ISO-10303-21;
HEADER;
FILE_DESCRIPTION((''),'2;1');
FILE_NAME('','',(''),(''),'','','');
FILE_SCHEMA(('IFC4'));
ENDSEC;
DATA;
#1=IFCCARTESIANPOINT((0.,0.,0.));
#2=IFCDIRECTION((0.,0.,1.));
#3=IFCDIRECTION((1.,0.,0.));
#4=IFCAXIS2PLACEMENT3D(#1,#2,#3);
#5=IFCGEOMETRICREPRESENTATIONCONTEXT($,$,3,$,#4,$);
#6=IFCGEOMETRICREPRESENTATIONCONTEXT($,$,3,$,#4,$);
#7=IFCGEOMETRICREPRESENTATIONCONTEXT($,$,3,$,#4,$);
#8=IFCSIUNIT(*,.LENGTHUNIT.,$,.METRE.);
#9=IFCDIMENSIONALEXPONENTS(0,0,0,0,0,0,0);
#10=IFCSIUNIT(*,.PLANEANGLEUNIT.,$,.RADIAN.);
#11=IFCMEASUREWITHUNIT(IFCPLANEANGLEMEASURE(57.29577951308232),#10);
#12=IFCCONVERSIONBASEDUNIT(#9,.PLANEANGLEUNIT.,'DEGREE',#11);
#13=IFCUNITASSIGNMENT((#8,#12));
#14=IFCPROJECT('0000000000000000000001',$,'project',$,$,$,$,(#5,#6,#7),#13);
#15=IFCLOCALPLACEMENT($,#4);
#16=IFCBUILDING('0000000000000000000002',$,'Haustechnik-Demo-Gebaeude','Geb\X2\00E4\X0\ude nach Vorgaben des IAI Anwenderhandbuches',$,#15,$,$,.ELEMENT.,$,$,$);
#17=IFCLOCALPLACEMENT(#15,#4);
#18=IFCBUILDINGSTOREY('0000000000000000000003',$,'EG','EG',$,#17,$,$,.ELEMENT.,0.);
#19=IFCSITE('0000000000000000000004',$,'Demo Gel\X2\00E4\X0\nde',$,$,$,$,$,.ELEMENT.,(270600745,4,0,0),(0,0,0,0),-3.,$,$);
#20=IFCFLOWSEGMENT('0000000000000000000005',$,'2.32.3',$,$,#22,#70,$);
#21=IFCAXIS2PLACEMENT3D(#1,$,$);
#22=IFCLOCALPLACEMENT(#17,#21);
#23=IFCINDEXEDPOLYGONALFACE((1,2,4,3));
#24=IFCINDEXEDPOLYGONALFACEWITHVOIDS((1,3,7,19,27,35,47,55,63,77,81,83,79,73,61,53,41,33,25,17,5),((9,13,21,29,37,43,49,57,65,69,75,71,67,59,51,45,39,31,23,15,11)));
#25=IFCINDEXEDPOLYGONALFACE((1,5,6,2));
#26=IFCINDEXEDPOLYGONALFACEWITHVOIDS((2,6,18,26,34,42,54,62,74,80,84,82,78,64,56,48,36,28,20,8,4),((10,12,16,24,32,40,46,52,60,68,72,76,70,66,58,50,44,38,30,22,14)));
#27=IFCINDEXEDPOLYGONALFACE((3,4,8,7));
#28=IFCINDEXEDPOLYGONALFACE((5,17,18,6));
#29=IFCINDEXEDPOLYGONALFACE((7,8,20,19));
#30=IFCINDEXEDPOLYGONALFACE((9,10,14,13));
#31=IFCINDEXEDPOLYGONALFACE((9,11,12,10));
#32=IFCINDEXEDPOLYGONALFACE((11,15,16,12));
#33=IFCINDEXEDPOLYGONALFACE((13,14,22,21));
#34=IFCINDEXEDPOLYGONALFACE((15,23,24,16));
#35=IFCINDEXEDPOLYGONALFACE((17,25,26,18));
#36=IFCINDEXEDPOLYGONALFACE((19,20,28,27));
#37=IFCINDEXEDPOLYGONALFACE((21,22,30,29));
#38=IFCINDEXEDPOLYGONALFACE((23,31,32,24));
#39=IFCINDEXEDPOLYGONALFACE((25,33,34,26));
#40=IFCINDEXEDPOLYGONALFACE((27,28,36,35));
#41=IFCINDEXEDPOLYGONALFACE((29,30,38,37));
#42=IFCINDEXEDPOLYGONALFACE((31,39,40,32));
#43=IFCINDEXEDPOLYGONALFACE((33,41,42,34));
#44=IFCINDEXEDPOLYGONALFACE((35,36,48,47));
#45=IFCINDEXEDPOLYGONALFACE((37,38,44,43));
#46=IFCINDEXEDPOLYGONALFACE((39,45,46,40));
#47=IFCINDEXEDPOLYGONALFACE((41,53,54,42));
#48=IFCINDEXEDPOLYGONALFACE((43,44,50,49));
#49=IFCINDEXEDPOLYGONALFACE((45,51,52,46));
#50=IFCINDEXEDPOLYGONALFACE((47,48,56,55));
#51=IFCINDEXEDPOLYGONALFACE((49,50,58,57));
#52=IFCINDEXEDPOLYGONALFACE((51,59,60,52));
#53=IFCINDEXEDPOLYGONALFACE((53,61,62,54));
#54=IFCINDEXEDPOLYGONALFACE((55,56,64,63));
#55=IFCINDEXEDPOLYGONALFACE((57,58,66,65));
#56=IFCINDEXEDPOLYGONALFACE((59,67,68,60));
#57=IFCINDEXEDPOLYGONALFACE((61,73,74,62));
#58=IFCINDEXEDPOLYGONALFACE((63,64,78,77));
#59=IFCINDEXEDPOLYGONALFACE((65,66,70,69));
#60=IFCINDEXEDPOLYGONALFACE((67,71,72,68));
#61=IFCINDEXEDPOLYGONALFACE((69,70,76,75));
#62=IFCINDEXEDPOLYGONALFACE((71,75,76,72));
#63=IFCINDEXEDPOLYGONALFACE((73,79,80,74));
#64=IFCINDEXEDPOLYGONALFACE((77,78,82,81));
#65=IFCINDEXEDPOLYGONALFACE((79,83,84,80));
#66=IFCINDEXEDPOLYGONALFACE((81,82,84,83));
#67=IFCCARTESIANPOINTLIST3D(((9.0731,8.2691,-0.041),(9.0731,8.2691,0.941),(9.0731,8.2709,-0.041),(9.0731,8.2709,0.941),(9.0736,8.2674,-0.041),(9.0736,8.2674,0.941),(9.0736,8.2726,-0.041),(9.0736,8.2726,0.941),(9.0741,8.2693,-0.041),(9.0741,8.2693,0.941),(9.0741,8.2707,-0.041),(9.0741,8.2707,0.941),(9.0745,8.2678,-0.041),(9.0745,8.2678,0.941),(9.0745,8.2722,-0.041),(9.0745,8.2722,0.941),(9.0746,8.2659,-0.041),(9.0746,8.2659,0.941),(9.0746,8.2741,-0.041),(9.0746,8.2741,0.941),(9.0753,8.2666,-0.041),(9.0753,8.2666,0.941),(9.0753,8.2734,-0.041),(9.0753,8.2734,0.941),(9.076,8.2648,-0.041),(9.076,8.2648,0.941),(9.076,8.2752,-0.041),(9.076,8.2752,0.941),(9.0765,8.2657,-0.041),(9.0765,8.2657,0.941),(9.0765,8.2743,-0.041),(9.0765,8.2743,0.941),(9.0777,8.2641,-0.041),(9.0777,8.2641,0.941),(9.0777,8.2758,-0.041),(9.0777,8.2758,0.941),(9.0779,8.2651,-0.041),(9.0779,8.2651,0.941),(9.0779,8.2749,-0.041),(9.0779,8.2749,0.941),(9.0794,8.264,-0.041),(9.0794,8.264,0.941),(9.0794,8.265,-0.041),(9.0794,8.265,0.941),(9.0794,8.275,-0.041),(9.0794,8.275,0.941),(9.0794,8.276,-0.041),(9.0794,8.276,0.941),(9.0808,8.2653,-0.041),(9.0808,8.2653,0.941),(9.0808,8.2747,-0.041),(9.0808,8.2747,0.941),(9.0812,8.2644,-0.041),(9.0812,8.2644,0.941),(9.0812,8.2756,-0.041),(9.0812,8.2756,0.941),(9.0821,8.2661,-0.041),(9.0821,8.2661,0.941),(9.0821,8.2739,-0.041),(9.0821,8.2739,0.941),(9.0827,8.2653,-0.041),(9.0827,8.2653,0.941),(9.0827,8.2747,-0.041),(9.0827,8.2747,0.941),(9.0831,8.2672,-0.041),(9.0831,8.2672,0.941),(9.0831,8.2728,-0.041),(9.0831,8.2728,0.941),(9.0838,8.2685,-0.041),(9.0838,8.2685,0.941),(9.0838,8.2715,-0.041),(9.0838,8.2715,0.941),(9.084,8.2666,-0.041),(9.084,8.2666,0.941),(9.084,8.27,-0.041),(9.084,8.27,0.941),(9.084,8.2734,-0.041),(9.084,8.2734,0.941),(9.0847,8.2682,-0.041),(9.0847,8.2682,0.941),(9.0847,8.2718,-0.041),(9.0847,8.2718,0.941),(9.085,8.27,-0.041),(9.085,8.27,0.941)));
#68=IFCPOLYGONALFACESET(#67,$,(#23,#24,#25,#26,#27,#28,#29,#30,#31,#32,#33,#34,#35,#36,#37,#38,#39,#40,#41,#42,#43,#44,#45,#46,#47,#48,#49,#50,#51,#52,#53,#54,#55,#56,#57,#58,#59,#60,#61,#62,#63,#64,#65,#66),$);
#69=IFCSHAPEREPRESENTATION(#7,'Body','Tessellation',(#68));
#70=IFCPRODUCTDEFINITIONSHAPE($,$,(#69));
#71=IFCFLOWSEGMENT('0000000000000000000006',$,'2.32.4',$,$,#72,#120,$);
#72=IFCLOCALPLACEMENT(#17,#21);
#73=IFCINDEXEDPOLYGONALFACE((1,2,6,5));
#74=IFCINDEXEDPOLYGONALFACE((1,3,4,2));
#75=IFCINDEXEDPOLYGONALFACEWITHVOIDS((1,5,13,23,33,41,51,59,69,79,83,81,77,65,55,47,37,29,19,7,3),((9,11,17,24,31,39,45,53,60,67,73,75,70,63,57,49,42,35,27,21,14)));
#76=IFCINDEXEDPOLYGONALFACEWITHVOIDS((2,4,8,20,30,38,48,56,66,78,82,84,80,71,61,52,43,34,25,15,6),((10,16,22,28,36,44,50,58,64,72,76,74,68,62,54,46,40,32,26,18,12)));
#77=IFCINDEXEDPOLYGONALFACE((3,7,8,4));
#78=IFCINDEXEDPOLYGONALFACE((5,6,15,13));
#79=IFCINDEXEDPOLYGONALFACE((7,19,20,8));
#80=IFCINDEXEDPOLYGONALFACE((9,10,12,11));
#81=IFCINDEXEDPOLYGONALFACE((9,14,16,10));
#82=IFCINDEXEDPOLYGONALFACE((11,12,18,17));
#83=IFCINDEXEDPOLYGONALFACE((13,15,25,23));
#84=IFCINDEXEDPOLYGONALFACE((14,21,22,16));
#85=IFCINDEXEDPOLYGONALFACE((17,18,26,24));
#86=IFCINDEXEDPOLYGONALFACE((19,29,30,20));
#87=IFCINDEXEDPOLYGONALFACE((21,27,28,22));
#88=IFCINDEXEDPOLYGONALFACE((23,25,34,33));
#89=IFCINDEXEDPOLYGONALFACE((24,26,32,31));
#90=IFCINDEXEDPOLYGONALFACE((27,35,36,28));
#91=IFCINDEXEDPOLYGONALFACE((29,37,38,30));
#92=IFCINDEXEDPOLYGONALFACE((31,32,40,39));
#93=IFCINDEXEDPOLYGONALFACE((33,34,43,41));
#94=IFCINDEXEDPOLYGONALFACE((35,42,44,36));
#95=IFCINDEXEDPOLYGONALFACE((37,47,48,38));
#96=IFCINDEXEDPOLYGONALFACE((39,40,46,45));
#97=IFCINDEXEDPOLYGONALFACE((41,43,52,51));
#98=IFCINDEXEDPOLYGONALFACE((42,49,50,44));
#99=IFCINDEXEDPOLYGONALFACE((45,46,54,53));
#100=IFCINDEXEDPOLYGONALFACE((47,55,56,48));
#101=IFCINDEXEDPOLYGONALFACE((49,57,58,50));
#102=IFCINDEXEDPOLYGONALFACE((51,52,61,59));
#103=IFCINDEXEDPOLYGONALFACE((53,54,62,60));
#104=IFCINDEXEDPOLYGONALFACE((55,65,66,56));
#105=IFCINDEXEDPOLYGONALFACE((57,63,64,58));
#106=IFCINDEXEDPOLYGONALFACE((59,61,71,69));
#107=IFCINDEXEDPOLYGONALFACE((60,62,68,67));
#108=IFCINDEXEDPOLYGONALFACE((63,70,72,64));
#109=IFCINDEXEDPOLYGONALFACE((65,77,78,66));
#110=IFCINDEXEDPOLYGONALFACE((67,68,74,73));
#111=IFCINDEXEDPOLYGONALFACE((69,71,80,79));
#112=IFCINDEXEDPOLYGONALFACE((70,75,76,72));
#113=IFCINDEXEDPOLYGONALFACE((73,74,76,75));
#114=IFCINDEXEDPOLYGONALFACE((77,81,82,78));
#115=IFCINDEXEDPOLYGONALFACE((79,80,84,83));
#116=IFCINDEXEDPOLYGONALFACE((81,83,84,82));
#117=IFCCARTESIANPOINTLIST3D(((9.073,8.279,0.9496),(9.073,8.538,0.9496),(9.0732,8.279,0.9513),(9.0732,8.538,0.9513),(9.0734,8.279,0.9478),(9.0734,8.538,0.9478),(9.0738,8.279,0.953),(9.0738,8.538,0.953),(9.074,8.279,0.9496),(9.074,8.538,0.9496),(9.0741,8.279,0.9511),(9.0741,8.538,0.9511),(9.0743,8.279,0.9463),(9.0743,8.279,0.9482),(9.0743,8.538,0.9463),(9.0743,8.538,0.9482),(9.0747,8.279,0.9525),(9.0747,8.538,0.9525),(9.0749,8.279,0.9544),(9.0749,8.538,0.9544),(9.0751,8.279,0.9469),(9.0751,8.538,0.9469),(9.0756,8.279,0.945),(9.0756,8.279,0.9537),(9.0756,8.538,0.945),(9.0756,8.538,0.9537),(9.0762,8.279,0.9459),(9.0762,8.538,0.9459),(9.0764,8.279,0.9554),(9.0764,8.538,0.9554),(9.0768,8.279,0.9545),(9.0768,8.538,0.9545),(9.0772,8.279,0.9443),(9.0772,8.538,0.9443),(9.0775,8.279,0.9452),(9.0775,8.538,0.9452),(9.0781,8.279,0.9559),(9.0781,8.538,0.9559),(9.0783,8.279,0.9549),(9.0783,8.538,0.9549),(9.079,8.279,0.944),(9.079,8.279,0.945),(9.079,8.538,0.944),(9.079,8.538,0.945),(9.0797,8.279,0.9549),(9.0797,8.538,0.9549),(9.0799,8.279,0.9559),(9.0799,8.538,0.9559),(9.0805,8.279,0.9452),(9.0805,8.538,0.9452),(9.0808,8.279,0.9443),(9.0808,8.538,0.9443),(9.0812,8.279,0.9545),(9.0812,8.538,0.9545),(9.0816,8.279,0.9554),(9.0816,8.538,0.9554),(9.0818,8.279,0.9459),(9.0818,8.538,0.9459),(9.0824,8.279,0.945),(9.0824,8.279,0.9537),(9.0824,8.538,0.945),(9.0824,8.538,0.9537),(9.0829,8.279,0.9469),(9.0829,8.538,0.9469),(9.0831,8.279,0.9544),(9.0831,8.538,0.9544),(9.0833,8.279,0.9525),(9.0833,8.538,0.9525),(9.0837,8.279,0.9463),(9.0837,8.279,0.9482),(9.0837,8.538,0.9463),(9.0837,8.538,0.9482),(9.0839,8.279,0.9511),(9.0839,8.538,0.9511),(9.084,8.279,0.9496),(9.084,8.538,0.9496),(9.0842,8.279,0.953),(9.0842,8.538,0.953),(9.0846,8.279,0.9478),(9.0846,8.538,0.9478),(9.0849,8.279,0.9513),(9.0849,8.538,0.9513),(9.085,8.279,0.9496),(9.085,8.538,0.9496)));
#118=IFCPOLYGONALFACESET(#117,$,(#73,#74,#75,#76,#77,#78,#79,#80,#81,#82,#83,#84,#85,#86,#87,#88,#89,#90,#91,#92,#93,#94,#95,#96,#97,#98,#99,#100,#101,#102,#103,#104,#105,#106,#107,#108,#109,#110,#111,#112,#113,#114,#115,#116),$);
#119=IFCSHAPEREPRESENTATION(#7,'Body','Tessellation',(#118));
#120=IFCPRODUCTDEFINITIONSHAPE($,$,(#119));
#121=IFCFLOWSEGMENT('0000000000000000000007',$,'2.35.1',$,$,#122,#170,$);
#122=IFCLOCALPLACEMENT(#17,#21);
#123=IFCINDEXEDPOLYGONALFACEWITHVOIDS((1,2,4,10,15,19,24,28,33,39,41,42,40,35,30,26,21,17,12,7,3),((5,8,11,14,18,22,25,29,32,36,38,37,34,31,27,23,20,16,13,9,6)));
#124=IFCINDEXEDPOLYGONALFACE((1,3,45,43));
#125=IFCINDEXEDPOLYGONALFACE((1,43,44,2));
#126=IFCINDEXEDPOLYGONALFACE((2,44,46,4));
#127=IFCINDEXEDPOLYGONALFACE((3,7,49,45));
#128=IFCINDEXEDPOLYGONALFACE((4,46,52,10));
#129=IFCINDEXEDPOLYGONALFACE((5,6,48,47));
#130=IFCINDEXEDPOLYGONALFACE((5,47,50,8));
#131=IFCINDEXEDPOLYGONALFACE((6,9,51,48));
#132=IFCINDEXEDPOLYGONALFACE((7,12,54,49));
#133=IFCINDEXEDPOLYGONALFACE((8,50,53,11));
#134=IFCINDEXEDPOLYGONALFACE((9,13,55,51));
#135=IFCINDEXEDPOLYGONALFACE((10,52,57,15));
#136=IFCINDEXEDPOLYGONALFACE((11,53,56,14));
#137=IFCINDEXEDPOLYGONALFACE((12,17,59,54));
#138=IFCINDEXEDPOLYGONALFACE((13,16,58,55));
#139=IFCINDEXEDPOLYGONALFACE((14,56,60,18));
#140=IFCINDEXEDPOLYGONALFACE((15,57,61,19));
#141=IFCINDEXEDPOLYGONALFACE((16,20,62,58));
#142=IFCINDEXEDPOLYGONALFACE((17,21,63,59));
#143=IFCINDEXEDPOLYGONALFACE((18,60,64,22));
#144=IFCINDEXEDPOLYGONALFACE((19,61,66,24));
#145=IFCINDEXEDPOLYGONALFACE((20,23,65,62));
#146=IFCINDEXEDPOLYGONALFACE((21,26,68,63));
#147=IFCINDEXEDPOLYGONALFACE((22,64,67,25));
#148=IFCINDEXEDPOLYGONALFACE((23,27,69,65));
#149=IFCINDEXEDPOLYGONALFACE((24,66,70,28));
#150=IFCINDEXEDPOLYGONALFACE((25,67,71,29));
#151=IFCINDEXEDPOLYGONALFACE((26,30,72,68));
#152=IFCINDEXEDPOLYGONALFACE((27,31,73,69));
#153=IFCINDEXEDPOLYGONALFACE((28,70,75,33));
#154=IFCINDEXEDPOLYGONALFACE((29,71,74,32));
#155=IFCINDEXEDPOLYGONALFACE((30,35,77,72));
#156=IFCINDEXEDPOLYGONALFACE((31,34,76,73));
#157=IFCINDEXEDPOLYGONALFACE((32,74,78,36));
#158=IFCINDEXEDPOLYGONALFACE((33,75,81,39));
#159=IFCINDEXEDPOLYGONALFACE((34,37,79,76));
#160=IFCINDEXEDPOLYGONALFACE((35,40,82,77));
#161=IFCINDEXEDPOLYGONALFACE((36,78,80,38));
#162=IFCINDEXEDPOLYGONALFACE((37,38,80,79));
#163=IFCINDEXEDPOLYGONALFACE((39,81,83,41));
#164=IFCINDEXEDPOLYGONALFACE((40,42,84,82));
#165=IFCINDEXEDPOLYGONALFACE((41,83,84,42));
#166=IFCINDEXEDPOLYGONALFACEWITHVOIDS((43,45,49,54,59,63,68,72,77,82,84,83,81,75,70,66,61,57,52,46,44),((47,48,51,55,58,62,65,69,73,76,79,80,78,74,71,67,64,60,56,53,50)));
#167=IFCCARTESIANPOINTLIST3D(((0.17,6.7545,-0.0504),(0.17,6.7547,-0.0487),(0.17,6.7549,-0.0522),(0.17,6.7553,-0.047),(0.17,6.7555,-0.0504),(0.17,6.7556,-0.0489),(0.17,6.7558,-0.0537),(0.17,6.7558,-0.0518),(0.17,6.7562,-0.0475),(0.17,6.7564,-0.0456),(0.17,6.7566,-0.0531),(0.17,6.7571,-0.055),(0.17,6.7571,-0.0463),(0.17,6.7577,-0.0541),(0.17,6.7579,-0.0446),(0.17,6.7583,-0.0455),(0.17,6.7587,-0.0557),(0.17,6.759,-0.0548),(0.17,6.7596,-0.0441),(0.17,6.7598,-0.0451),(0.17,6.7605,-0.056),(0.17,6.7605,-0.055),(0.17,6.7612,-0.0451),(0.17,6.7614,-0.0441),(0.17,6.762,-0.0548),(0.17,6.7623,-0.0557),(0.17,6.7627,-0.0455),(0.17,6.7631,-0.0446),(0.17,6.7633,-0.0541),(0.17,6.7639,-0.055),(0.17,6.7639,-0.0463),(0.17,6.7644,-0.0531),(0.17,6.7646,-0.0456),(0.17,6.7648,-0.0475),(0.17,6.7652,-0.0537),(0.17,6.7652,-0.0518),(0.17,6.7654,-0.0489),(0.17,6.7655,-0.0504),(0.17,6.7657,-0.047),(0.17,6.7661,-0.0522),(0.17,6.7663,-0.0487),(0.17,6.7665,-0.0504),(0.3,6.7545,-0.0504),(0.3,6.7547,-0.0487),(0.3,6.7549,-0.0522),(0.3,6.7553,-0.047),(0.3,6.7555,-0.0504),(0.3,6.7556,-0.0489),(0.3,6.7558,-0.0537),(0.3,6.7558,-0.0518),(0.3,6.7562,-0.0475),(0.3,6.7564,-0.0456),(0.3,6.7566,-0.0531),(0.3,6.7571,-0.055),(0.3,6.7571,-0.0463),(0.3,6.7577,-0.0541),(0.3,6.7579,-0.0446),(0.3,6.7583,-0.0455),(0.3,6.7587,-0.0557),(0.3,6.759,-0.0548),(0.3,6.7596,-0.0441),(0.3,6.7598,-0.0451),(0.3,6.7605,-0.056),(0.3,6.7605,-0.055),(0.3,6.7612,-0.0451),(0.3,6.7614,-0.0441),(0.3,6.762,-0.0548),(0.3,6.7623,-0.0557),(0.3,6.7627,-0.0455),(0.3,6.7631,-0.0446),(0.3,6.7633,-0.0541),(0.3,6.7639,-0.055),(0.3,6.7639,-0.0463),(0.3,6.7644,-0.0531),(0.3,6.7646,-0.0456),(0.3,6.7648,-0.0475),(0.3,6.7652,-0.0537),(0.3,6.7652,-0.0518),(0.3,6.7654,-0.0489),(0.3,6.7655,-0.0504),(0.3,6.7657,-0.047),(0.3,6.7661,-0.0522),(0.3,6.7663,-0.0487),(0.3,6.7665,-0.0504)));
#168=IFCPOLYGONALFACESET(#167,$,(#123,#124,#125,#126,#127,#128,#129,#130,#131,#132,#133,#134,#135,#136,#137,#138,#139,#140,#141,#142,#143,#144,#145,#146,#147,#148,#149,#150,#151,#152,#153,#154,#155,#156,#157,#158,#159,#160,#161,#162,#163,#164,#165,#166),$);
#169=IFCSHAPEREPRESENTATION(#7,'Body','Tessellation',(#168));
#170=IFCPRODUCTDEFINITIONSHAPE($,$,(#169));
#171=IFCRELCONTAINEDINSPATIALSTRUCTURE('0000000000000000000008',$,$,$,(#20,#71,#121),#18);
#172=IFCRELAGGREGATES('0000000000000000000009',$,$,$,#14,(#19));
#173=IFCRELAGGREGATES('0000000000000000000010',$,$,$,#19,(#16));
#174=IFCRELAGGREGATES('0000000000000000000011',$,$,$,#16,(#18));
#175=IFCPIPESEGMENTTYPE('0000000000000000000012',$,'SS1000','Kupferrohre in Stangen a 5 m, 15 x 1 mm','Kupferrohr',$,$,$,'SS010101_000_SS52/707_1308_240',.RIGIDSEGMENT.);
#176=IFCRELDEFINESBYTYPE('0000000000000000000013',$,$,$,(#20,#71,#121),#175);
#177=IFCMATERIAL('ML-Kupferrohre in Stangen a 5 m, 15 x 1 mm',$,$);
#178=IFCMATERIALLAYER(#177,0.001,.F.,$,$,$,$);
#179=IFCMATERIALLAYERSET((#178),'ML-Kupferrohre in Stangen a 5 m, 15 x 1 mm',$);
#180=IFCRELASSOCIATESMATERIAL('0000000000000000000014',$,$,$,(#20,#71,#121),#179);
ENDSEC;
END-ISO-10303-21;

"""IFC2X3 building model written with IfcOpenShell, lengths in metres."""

from ifc_helpers import new_model, entity, si_unit, converted_unit, frame, origin_with_axes, origin_2d_with_axis, place, context, project, spatial, hollow_circle, extrude, material, layer, layer_set, layer_usage, type_object, element, save


model = new_model("IFC2X3")

# Units and contexts
context_of_model_1 = context(None, 3, world=origin_with_axes())
context_of_model_2 = context(None, 3, world=origin_with_axes())
context_of_model_3 = context(None, 3, world=origin_with_axes())
ifc_project = project(units=[si_unit("LENGTHUNIT", "METRE"), converted_unit("PLANEANGLEUNIT", "DEGREE", entity("IfcPlaneAngleMeasure", 57.29577951308232), si_unit("PLANEANGLEUNIT", "RADIAN"), dimensions=[0, 0, 0, 0, 0, 0, 0])], contexts=[context_of_model_1, context_of_model_2, context_of_model_3])

# Site, building, storey
site = spatial("IfcSite", under=ifc_project, Name="Demo Gelände", CompositionType="ELEMENT", RefLatitude=(270600745, 4, 0, 0), RefLongitude=(0, 0, 0, 0), RefElevation=-3.0)
building_placement = place(None, origin_with_axes())
building = spatial("IfcBuilding", under=site, at=building_placement, Name="Haustechnik-Demo-Gebaeude", Description="Gebäude nach Vorgaben des IAI Anwenderhandbuches", CompositionType="ELEMENT")
storey_placement = place(building_placement, origin_with_axes())
storey = spatial("IfcBuildingStorey", under=building, at=storey_placement, Name="EG", Description="EG", CompositionType="ELEMENT", Elevation=0.0)

# Flow segments
ifc_material_1 = material(Name="ML-Kupferrohre in Stangen a 5 m, 15 x 1 mm")
ifc_layer_1 = layer(ifc_material_1, 0.001, ventilated=False)
ifc_layer_set_1 = layer_set([ifc_layer_1], Name="ML-Kupferrohre in Stangen a 5 m, 15 x 1 mm")
ifc_layer_usage_1 = layer_usage(ifc_layer_set_1, "AXIS2", "POSITIVE", 0.0)
pipe_segment_type_1 = type_object("IfcPipeSegmentType", Name="SS1000", Description="Kupferrohre in Stangen a 5 m, 15 x 1 mm", ApplicableOccurrence="Kupferrohr", ElementType="SS010101_000_SS52/707_1308_240", PredefinedType="RIGIDSEGMENT")
flow_segment_1_placement = place(storey_placement, frame((9.079, 8.27, -0.041), z_axis=(0.0, 0.0, 1.0), x_axis=(1.0, 0.0, 0.0)))
element("IfcFlowSegment", 1, at=flow_segment_1_placement, inside=storey, type_object=pipe_segment_type_1, material=ifc_layer_usage_1, Name="2.32.3", context=context_of_model_3, shape_type="SweptSolid", body=[
    extrude(hollow_circle(Radius=0.006, WallThickness=0.001, at=origin_2d_with_axis()), origin_with_axes(), (0.0, 0.0, 1.0), 0.982),
])
flow_segment_2_placement = place(storey_placement, frame((9.079, 8.279, 0.95), z_axis=(0.0, 1.0, 0.0), x_axis=(0.0, 0.0, -1.0)))
element("IfcFlowSegment", 2, at=flow_segment_2_placement, inside=storey, type_object=pipe_segment_type_1, material=ifc_layer_usage_1, Name="2.32.4", context=context_of_model_3, shape_type="SweptSolid", body=[
    extrude(hollow_circle(Radius=0.006, WallThickness=0.001, at=origin_2d_with_axis()), origin_with_axes(), (0.0, 0.0, 1.0), 0.259),
])
flow_segment_3_placement = place(storey_placement, frame((0.3, 6.7605, -0.05), z_axis=(-1.0, 0.0, 0.0), x_axis=(0.0, 0.0, -1.0)))
element("IfcFlowSegment", 3, at=flow_segment_3_placement, inside=storey, type_object=pipe_segment_type_1, material=ifc_layer_usage_1, Name="2.35.1", context=context_of_model_3, shape_type="SweptSolid", body=[
    extrude(hollow_circle(Radius=0.006, WallThickness=0.001, at=origin_2d_with_axis()), origin_with_axes(), (0.0, 0.0, 1.0), 0.13),
])

save(model, "model.ifc")
